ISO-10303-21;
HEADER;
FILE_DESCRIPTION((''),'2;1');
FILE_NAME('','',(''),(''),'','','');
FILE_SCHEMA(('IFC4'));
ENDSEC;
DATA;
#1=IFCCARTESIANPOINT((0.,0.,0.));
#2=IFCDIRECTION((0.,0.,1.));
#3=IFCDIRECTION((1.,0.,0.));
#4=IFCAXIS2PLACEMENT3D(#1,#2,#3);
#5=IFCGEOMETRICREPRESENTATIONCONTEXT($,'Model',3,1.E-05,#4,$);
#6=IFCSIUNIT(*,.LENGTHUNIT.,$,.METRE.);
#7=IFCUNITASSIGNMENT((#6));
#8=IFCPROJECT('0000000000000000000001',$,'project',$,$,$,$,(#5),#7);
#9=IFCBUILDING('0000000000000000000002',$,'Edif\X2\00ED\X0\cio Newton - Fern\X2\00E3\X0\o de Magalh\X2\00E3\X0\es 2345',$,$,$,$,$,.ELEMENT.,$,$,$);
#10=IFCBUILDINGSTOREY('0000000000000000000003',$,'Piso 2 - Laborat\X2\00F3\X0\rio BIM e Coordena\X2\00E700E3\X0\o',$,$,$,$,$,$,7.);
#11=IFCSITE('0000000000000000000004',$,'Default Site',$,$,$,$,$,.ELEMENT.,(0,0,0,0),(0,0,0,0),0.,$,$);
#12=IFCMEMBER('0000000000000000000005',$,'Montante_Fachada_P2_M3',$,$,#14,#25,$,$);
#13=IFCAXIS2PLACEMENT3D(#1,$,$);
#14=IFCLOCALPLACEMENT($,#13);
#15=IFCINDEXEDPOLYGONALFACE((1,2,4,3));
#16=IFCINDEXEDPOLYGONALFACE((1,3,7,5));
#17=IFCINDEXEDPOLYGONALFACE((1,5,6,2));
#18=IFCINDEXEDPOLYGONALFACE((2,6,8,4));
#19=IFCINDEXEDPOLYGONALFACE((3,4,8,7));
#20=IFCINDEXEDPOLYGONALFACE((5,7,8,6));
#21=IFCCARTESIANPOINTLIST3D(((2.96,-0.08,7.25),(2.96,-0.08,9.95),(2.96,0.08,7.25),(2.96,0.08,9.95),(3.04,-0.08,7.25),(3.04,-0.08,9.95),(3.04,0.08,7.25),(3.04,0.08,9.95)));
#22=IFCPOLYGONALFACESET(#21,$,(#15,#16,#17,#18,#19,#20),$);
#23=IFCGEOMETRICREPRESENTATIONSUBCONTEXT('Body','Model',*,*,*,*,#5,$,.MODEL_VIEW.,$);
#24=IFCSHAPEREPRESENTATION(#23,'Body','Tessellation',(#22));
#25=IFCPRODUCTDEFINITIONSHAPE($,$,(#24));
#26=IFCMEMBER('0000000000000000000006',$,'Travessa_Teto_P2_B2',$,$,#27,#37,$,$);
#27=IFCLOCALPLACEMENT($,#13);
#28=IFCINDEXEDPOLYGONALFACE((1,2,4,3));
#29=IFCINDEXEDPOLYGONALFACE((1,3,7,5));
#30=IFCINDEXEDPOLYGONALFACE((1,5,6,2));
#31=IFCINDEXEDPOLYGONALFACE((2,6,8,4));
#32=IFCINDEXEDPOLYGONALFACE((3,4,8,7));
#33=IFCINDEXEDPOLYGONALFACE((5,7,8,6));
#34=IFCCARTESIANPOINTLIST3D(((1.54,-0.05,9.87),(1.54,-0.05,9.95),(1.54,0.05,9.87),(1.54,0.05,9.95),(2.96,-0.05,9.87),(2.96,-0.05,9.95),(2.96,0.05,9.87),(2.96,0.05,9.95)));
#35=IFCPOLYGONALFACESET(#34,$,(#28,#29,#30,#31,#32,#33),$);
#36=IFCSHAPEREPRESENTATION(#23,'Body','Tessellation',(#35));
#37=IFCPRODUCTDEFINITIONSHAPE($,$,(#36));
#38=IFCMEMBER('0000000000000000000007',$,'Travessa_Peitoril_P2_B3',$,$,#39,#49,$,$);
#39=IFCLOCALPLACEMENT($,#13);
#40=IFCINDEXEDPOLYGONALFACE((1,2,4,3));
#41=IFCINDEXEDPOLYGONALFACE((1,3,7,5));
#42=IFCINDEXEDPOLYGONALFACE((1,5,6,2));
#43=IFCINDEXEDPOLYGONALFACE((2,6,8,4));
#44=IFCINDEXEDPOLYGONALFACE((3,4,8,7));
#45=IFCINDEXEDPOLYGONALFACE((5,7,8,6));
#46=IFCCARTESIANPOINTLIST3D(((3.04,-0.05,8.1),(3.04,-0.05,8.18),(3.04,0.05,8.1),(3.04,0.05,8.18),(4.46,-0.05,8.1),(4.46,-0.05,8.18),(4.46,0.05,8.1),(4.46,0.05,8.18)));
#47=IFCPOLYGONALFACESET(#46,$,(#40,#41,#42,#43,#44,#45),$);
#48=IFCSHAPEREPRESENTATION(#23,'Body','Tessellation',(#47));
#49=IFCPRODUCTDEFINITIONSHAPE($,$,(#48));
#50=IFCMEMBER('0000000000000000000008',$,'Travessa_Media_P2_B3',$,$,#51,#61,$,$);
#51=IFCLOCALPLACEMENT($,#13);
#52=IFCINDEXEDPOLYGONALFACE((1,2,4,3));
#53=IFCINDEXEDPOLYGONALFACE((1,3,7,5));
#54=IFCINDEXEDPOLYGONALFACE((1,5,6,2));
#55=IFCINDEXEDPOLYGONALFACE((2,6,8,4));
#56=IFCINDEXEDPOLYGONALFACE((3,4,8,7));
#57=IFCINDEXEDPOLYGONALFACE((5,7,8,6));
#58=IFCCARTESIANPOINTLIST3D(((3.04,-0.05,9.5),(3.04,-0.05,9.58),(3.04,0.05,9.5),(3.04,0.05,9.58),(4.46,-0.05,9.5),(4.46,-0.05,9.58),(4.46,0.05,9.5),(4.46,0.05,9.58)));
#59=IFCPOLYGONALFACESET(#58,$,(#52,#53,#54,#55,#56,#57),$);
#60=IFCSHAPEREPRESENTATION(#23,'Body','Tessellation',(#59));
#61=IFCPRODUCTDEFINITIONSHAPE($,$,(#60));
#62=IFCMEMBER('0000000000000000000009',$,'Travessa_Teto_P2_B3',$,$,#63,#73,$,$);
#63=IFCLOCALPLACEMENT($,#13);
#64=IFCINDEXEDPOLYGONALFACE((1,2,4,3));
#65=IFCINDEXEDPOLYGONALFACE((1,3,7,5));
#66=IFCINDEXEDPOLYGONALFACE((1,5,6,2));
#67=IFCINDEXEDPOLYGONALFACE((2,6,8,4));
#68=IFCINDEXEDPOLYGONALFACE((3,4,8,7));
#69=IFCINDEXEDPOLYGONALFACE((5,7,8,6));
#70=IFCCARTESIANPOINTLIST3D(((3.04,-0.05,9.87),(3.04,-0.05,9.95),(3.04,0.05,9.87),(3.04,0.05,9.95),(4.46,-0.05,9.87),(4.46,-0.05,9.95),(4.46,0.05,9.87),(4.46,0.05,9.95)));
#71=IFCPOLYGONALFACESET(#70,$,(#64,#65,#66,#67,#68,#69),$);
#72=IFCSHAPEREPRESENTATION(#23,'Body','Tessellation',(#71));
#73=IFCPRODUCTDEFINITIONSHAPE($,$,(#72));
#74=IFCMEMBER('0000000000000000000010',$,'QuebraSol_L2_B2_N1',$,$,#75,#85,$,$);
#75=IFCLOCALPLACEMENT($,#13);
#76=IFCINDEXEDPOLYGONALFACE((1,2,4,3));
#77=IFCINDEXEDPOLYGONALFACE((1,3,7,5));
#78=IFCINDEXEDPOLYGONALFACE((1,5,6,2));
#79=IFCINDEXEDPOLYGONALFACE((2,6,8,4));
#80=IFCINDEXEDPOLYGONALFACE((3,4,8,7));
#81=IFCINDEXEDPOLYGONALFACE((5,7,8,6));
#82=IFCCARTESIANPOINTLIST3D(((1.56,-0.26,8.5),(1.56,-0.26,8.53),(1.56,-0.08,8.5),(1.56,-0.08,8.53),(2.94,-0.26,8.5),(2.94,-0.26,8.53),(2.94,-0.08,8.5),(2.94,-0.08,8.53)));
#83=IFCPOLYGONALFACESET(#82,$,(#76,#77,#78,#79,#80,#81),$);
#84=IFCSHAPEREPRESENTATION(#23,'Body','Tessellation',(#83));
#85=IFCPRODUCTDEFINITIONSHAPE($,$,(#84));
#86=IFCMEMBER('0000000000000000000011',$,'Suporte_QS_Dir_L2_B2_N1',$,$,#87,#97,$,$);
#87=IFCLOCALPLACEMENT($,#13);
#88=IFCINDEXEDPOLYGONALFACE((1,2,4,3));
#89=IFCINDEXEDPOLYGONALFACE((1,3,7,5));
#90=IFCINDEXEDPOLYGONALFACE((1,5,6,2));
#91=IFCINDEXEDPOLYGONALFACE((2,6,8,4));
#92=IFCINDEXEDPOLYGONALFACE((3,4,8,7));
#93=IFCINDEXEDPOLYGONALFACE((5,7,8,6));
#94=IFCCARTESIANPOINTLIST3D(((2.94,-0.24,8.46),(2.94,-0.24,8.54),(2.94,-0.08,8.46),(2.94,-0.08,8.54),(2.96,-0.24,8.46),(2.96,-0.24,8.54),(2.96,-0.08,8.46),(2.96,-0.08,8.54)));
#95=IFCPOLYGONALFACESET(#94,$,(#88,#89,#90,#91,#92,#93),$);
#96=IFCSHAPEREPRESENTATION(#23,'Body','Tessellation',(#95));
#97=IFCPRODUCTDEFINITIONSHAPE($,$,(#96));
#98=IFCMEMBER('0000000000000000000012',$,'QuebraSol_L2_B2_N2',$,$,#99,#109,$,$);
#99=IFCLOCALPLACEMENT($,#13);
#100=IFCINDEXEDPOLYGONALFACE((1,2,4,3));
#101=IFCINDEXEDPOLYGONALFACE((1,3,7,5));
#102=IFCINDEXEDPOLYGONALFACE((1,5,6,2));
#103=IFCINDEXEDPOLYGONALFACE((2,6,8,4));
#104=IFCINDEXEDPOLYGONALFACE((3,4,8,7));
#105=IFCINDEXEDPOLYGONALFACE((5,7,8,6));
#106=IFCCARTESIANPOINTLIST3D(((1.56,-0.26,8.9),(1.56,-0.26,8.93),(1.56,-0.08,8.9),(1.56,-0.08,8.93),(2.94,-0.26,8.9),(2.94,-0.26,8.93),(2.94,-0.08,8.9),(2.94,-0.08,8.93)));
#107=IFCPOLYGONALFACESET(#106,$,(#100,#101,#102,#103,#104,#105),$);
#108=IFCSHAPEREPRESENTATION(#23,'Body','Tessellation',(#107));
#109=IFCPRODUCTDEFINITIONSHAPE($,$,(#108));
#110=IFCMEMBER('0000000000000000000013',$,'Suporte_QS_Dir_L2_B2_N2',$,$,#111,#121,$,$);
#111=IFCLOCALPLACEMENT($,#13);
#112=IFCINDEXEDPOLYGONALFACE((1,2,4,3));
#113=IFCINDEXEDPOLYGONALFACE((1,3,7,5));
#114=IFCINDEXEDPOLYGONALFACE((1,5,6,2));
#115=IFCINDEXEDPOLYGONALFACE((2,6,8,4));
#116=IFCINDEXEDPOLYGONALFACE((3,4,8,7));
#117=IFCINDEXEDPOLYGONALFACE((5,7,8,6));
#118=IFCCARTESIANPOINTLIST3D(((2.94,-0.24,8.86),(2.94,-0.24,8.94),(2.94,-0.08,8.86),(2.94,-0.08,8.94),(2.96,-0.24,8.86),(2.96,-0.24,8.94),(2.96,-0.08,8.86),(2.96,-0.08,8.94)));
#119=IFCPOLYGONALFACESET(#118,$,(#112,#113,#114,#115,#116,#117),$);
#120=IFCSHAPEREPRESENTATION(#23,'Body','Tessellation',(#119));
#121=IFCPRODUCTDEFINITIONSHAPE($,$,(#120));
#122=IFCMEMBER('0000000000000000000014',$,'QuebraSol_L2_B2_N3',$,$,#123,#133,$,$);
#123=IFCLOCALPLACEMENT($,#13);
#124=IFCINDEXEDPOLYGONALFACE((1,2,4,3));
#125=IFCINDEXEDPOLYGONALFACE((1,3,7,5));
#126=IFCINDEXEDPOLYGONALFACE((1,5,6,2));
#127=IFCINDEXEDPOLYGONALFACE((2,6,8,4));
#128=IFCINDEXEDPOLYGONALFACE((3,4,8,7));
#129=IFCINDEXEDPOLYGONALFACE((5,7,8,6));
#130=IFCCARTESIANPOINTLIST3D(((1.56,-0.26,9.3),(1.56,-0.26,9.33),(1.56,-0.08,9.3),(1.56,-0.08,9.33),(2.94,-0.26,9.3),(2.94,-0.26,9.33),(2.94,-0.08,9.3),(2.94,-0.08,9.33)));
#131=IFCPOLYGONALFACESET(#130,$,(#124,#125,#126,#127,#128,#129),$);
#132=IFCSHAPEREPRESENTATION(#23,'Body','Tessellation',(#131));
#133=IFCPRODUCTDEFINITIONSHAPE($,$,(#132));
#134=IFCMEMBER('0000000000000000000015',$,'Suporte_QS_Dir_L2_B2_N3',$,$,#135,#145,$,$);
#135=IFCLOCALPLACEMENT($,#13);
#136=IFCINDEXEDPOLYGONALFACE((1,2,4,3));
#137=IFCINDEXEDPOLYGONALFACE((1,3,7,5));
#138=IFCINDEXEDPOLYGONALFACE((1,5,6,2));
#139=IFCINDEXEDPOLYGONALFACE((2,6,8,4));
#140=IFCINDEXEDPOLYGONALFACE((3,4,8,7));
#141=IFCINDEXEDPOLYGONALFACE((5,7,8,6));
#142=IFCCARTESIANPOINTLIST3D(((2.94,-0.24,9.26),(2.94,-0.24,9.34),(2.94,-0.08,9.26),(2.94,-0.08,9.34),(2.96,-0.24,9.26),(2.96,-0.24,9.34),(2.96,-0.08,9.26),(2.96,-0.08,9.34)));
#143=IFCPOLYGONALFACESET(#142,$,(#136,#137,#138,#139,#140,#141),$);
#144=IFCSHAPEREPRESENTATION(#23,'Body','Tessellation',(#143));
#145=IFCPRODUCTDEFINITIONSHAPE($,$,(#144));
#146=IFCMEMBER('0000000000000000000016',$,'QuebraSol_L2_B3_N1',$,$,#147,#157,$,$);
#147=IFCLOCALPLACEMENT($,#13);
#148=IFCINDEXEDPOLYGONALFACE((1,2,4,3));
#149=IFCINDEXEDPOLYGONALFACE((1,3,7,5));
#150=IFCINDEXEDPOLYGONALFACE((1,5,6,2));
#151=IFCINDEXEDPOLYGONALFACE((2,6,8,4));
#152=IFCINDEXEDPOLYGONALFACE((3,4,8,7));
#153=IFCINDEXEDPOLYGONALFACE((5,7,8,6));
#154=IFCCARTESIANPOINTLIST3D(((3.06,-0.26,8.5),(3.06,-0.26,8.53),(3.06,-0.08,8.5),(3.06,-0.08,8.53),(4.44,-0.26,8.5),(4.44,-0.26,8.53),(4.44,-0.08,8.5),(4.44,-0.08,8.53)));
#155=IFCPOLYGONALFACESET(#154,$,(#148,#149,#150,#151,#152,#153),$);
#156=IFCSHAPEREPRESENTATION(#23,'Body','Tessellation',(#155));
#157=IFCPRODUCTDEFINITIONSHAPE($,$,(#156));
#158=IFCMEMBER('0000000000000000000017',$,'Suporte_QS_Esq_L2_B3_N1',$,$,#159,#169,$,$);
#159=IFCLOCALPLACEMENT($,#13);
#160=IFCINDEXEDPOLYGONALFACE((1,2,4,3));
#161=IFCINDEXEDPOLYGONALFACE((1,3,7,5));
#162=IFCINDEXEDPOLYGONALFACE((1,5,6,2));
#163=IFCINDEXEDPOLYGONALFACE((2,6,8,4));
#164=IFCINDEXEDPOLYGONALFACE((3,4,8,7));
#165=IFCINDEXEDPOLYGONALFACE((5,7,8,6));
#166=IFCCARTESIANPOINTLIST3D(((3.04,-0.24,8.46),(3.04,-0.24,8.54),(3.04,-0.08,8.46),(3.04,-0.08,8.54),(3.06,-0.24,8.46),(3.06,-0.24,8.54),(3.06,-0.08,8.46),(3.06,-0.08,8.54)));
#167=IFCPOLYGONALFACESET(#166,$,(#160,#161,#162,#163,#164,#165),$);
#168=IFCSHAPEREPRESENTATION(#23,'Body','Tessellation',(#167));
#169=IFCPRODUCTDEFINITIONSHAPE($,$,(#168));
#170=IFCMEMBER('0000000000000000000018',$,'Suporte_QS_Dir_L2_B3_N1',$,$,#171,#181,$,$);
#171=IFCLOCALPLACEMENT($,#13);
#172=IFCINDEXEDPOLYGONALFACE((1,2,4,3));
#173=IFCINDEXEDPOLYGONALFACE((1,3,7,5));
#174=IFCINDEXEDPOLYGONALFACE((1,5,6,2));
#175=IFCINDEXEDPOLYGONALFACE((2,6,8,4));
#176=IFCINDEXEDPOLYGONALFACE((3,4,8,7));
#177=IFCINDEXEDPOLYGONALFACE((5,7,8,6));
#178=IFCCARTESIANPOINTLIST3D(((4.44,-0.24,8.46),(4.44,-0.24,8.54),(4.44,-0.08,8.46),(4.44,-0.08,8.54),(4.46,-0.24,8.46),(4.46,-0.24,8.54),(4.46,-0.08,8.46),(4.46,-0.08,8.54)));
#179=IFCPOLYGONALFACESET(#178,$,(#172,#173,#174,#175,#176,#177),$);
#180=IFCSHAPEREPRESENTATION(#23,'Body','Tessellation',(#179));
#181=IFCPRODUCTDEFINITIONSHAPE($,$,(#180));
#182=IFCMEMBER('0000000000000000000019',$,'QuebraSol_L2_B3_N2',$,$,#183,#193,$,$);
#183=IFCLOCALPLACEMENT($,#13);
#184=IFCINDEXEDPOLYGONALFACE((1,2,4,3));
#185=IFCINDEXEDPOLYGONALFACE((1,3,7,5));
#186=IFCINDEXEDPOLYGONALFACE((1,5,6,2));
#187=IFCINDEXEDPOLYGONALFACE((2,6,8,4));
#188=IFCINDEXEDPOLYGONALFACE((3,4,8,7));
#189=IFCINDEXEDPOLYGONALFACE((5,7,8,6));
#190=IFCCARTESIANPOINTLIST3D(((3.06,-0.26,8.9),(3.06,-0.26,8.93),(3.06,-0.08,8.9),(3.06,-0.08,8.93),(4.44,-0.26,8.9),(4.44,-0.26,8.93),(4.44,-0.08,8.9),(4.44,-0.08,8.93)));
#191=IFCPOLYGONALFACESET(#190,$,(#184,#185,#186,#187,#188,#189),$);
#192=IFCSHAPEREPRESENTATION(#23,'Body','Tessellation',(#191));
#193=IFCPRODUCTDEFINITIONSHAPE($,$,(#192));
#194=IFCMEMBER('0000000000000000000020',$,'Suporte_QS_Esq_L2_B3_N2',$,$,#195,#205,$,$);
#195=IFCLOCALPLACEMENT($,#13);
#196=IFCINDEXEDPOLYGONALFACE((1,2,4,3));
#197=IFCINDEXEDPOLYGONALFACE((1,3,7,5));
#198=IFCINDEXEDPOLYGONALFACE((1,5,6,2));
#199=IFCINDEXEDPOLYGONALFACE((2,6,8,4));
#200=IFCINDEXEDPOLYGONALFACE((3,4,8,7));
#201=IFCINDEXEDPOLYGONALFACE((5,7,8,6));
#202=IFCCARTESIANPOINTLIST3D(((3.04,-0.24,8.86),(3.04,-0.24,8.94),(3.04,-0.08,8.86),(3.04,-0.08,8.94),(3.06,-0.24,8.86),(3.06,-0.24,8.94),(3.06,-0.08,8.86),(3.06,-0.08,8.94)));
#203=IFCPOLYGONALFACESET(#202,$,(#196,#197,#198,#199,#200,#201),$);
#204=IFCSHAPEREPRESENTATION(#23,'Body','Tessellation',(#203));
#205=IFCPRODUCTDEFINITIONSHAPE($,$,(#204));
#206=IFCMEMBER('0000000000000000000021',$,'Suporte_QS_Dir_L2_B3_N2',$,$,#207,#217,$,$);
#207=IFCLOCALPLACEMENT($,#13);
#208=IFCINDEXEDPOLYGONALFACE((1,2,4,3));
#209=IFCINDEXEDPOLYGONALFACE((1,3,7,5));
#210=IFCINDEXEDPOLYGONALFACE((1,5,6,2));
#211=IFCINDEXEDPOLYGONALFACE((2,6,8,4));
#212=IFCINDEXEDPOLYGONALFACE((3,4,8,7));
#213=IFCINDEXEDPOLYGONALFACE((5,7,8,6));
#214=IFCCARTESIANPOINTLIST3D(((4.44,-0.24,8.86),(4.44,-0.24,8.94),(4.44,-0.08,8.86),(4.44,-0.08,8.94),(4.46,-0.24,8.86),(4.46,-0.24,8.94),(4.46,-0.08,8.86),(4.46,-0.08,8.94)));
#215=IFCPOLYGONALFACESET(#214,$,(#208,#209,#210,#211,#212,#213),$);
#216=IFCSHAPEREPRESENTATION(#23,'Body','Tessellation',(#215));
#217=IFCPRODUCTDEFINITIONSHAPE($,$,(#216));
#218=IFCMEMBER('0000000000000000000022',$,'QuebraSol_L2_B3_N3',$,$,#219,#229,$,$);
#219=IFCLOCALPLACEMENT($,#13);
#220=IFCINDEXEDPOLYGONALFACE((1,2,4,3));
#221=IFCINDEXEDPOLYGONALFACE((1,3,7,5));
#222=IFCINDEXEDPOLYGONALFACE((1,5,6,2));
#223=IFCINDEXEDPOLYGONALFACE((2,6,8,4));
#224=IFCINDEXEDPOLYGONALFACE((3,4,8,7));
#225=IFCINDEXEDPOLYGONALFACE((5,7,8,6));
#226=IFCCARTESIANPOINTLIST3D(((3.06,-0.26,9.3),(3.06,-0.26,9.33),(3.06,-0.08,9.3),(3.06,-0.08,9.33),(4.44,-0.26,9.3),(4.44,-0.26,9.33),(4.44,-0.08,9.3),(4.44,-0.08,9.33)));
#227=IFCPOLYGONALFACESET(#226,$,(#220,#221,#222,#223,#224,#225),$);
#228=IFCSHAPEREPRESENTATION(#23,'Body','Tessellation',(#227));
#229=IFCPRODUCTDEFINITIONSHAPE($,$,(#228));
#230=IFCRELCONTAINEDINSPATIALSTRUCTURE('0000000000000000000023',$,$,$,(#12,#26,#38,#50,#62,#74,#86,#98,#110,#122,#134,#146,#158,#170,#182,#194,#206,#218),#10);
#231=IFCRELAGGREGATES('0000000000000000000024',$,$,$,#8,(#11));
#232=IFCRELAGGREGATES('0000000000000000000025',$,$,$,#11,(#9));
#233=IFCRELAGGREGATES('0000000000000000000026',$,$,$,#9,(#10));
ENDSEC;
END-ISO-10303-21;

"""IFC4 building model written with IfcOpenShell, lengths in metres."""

from ifc_helpers import new_model, si_unit, frame, frame_2d, origin_with_axes, place, context, subcontext, project, spatial, rectangle, extrude, element, save


model = new_model("IFC4")

# Units and contexts
model_context = context("Model", 3, precision=1e-05, world=origin_with_axes())
body_context = subcontext(model_context, "Body", "Model", "MODEL_VIEW")
ifc_project = project(units=[si_unit("LENGTHUNIT", "METRE")], contexts=[model_context])

# Site, building, storey
site = spatial("IfcSite", under=ifc_project, Name="Default Site", CompositionType="ELEMENT", RefLatitude=(0, 0, 0, 0), RefLongitude=(0, 0, 0, 0), RefElevation=0.0)
building = spatial("IfcBuilding", under=site, Name="Edifício Newton - Fernão de Magalhães 2345", CompositionType="ELEMENT")
storey = spatial("IfcBuildingStorey", under=building, Name="Piso 2 - Laboratório BIM e Coordenação", Elevation=7.0)

# Members
member_1_placement = place(None, frame((2.96, -0.08, 7.25), z_axis=(0.0, 0.0, 1.0), x_axis=(1.0, 0.0, 0.0)))
element("IfcMember", 1, at=member_1_placement, inside=storey, Name="Montante_Fachada_P2_M3", context=body_context, shape_type="SweptSolid", body=[
    extrude(rectangle(XDim=0.08, YDim=0.16, at=frame_2d((0.04, 0.08))), origin_with_axes(), (0.0, 0.0, 1.0), 2.7),
])
for number, where, z_axis, x_axis, name in (
    (2, (1.54, -0.05, 9.87), (0.0, 0.0, 1.0), (1.0, 0.0, 0.0), "Travessa_Teto_P2_B2"),
    (3, (3.04, -0.05, 8.1), (0.0, 0.0, 1.0), (1.0, 0.0, 0.0), "Travessa_Peitoril_P2_B3"),
    (4, (3.04, -0.05, 9.5), (0.0, 0.0, 1.0), (1.0, 0.0, 0.0), "Travessa_Media_P2_B3"),
    (5, (3.04, -0.05, 9.87), (0.0, 0.0, 1.0), (1.0, 0.0, 0.0), "Travessa_Teto_P2_B3"),
):
    element("IfcMember", number, at=place(None, frame(where, z_axis=z_axis, x_axis=x_axis)), inside=storey, Name=name, context=body_context, shape_type="SweptSolid", body=[
        extrude(rectangle(XDim=1.42, YDim=0.1, at=frame_2d((0.71, 0.05))), origin_with_axes(), (0.0, 0.0, 1.0), 0.08),
    ])
member_2_placement = place(None, frame((1.56, -0.26, 8.5), z_axis=(0.0, 0.0, 1.0), x_axis=(1.0, 0.0, 0.0)))
element("IfcMember", 6, at=member_2_placement, inside=storey, Name="QuebraSol_L2_B2_N1", context=body_context, shape_type="SweptSolid", body=[
    extrude(rectangle(XDim=1.38, YDim=0.18, at=frame_2d((0.69, 0.09))), origin_with_axes(), (0.0, 0.0, 1.0), 0.03),
])
member_3_placement = place(None, frame((2.94, -0.24, 8.46), z_axis=(0.0, 0.0, 1.0), x_axis=(1.0, 0.0, 0.0)))
element("IfcMember", 7, at=member_3_placement, inside=storey, Name="Suporte_QS_Dir_L2_B2_N1", context=body_context, shape_type="SweptSolid", body=[
    extrude(rectangle(XDim=0.02, YDim=0.16, at=frame_2d((0.01, 0.08))), origin_with_axes(), (0.0, 0.0, 1.0), 0.08),
])
member_4_placement = place(None, frame((1.56, -0.26, 8.9), z_axis=(0.0, 0.0, 1.0), x_axis=(1.0, 0.0, 0.0)))
element("IfcMember", 8, at=member_4_placement, inside=storey, Name="QuebraSol_L2_B2_N2", context=body_context, shape_type="SweptSolid", body=[
    extrude(rectangle(XDim=1.38, YDim=0.18, at=frame_2d((0.69, 0.09))), origin_with_axes(), (0.0, 0.0, 1.0), 0.03),
])
member_5_placement = place(None, frame((2.94, -0.24, 8.86), z_axis=(0.0, 0.0, 1.0), x_axis=(1.0, 0.0, 0.0)))
element("IfcMember", 9, at=member_5_placement, inside=storey, Name="Suporte_QS_Dir_L2_B2_N2", context=body_context, shape_type="SweptSolid", body=[
    extrude(rectangle(XDim=0.02, YDim=0.16, at=frame_2d((0.01, 0.08))), origin_with_axes(), (0.0, 0.0, 1.0), 0.08),
])
member_6_placement = place(None, frame((1.56, -0.26, 9.3), z_axis=(0.0, 0.0, 1.0), x_axis=(1.0, 0.0, 0.0)))
element("IfcMember", 10, at=member_6_placement, inside=storey, Name="QuebraSol_L2_B2_N3", context=body_context, shape_type="SweptSolid", body=[
    extrude(rectangle(XDim=1.38, YDim=0.18, at=frame_2d((0.69, 0.09))), origin_with_axes(), (0.0, 0.0, 1.0), 0.03),
])
member_7_placement = place(None, frame((2.94, -0.24, 9.26), z_axis=(0.0, 0.0, 1.0), x_axis=(1.0, 0.0, 0.0)))
element("IfcMember", 11, at=member_7_placement, inside=storey, Name="Suporte_QS_Dir_L2_B2_N3", context=body_context, shape_type="SweptSolid", body=[
    extrude(rectangle(XDim=0.02, YDim=0.16, at=frame_2d((0.01, 0.08))), origin_with_axes(), (0.0, 0.0, 1.0), 0.08),
])
member_8_placement = place(None, frame((3.06, -0.26, 8.5), z_axis=(0.0, 0.0, 1.0), x_axis=(1.0, 0.0, 0.0)))
element("IfcMember", 12, at=member_8_placement, inside=storey, Name="QuebraSol_L2_B3_N1", context=body_context, shape_type="SweptSolid", body=[
    extrude(rectangle(XDim=1.38, YDim=0.18, at=frame_2d((0.69, 0.09))), origin_with_axes(), (0.0, 0.0, 1.0), 0.03),
])
for number, where, z_axis, x_axis, name in (
    (13, (3.04, -0.24, 8.46), (0.0, 0.0, 1.0), (1.0, 0.0, 0.0), "Suporte_QS_Esq_L2_B3_N1"),
    (14, (4.44, -0.24, 8.46), (0.0, 0.0, 1.0), (1.0, 0.0, 0.0), "Suporte_QS_Dir_L2_B3_N1"),
):
    element("IfcMember", number, at=place(None, frame(where, z_axis=z_axis, x_axis=x_axis)), inside=storey, Name=name, context=body_context, shape_type="SweptSolid", body=[
        extrude(rectangle(XDim=0.02, YDim=0.16, at=frame_2d((0.01, 0.08))), origin_with_axes(), (0.0, 0.0, 1.0), 0.08),
    ])
member_9_placement = place(None, frame((3.06, -0.26, 8.9), z_axis=(0.0, 0.0, 1.0), x_axis=(1.0, 0.0, 0.0)))
element("IfcMember", 15, at=member_9_placement, inside=storey, Name="QuebraSol_L2_B3_N2", context=body_context, shape_type="SweptSolid", body=[
    extrude(rectangle(XDim=1.38, YDim=0.18, at=frame_2d((0.69, 0.09))), origin_with_axes(), (0.0, 0.0, 1.0), 0.03),
])
for number, where, z_axis, x_axis, name in (
    (16, (3.04, -0.24, 8.86), (0.0, 0.0, 1.0), (1.0, 0.0, 0.0), "Suporte_QS_Esq_L2_B3_N2"),
    (17, (4.44, -0.24, 8.86), (0.0, 0.0, 1.0), (1.0, 0.0, 0.0), "Suporte_QS_Dir_L2_B3_N2"),
):
    element("IfcMember", number, at=place(None, frame(where, z_axis=z_axis, x_axis=x_axis)), inside=storey, Name=name, context=body_context, shape_type="SweptSolid", body=[
        extrude(rectangle(XDim=0.02, YDim=0.16, at=frame_2d((0.01, 0.08))), origin_with_axes(), (0.0, 0.0, 1.0), 0.08),
    ])
member_10_placement = place(None, frame((3.06, -0.26, 9.3), z_axis=(0.0, 0.0, 1.0), x_axis=(1.0, 0.0, 0.0)))
element("IfcMember", 18, at=member_10_placement, inside=storey, Name="QuebraSol_L2_B3_N3", context=body_context, shape_type="SweptSolid", body=[
    extrude(rectangle(XDim=1.38, YDim=0.18, at=frame_2d((0.69, 0.09))), origin_with_axes(), (0.0, 0.0, 1.0), 0.03),
])

save(model, "model.ifc")
